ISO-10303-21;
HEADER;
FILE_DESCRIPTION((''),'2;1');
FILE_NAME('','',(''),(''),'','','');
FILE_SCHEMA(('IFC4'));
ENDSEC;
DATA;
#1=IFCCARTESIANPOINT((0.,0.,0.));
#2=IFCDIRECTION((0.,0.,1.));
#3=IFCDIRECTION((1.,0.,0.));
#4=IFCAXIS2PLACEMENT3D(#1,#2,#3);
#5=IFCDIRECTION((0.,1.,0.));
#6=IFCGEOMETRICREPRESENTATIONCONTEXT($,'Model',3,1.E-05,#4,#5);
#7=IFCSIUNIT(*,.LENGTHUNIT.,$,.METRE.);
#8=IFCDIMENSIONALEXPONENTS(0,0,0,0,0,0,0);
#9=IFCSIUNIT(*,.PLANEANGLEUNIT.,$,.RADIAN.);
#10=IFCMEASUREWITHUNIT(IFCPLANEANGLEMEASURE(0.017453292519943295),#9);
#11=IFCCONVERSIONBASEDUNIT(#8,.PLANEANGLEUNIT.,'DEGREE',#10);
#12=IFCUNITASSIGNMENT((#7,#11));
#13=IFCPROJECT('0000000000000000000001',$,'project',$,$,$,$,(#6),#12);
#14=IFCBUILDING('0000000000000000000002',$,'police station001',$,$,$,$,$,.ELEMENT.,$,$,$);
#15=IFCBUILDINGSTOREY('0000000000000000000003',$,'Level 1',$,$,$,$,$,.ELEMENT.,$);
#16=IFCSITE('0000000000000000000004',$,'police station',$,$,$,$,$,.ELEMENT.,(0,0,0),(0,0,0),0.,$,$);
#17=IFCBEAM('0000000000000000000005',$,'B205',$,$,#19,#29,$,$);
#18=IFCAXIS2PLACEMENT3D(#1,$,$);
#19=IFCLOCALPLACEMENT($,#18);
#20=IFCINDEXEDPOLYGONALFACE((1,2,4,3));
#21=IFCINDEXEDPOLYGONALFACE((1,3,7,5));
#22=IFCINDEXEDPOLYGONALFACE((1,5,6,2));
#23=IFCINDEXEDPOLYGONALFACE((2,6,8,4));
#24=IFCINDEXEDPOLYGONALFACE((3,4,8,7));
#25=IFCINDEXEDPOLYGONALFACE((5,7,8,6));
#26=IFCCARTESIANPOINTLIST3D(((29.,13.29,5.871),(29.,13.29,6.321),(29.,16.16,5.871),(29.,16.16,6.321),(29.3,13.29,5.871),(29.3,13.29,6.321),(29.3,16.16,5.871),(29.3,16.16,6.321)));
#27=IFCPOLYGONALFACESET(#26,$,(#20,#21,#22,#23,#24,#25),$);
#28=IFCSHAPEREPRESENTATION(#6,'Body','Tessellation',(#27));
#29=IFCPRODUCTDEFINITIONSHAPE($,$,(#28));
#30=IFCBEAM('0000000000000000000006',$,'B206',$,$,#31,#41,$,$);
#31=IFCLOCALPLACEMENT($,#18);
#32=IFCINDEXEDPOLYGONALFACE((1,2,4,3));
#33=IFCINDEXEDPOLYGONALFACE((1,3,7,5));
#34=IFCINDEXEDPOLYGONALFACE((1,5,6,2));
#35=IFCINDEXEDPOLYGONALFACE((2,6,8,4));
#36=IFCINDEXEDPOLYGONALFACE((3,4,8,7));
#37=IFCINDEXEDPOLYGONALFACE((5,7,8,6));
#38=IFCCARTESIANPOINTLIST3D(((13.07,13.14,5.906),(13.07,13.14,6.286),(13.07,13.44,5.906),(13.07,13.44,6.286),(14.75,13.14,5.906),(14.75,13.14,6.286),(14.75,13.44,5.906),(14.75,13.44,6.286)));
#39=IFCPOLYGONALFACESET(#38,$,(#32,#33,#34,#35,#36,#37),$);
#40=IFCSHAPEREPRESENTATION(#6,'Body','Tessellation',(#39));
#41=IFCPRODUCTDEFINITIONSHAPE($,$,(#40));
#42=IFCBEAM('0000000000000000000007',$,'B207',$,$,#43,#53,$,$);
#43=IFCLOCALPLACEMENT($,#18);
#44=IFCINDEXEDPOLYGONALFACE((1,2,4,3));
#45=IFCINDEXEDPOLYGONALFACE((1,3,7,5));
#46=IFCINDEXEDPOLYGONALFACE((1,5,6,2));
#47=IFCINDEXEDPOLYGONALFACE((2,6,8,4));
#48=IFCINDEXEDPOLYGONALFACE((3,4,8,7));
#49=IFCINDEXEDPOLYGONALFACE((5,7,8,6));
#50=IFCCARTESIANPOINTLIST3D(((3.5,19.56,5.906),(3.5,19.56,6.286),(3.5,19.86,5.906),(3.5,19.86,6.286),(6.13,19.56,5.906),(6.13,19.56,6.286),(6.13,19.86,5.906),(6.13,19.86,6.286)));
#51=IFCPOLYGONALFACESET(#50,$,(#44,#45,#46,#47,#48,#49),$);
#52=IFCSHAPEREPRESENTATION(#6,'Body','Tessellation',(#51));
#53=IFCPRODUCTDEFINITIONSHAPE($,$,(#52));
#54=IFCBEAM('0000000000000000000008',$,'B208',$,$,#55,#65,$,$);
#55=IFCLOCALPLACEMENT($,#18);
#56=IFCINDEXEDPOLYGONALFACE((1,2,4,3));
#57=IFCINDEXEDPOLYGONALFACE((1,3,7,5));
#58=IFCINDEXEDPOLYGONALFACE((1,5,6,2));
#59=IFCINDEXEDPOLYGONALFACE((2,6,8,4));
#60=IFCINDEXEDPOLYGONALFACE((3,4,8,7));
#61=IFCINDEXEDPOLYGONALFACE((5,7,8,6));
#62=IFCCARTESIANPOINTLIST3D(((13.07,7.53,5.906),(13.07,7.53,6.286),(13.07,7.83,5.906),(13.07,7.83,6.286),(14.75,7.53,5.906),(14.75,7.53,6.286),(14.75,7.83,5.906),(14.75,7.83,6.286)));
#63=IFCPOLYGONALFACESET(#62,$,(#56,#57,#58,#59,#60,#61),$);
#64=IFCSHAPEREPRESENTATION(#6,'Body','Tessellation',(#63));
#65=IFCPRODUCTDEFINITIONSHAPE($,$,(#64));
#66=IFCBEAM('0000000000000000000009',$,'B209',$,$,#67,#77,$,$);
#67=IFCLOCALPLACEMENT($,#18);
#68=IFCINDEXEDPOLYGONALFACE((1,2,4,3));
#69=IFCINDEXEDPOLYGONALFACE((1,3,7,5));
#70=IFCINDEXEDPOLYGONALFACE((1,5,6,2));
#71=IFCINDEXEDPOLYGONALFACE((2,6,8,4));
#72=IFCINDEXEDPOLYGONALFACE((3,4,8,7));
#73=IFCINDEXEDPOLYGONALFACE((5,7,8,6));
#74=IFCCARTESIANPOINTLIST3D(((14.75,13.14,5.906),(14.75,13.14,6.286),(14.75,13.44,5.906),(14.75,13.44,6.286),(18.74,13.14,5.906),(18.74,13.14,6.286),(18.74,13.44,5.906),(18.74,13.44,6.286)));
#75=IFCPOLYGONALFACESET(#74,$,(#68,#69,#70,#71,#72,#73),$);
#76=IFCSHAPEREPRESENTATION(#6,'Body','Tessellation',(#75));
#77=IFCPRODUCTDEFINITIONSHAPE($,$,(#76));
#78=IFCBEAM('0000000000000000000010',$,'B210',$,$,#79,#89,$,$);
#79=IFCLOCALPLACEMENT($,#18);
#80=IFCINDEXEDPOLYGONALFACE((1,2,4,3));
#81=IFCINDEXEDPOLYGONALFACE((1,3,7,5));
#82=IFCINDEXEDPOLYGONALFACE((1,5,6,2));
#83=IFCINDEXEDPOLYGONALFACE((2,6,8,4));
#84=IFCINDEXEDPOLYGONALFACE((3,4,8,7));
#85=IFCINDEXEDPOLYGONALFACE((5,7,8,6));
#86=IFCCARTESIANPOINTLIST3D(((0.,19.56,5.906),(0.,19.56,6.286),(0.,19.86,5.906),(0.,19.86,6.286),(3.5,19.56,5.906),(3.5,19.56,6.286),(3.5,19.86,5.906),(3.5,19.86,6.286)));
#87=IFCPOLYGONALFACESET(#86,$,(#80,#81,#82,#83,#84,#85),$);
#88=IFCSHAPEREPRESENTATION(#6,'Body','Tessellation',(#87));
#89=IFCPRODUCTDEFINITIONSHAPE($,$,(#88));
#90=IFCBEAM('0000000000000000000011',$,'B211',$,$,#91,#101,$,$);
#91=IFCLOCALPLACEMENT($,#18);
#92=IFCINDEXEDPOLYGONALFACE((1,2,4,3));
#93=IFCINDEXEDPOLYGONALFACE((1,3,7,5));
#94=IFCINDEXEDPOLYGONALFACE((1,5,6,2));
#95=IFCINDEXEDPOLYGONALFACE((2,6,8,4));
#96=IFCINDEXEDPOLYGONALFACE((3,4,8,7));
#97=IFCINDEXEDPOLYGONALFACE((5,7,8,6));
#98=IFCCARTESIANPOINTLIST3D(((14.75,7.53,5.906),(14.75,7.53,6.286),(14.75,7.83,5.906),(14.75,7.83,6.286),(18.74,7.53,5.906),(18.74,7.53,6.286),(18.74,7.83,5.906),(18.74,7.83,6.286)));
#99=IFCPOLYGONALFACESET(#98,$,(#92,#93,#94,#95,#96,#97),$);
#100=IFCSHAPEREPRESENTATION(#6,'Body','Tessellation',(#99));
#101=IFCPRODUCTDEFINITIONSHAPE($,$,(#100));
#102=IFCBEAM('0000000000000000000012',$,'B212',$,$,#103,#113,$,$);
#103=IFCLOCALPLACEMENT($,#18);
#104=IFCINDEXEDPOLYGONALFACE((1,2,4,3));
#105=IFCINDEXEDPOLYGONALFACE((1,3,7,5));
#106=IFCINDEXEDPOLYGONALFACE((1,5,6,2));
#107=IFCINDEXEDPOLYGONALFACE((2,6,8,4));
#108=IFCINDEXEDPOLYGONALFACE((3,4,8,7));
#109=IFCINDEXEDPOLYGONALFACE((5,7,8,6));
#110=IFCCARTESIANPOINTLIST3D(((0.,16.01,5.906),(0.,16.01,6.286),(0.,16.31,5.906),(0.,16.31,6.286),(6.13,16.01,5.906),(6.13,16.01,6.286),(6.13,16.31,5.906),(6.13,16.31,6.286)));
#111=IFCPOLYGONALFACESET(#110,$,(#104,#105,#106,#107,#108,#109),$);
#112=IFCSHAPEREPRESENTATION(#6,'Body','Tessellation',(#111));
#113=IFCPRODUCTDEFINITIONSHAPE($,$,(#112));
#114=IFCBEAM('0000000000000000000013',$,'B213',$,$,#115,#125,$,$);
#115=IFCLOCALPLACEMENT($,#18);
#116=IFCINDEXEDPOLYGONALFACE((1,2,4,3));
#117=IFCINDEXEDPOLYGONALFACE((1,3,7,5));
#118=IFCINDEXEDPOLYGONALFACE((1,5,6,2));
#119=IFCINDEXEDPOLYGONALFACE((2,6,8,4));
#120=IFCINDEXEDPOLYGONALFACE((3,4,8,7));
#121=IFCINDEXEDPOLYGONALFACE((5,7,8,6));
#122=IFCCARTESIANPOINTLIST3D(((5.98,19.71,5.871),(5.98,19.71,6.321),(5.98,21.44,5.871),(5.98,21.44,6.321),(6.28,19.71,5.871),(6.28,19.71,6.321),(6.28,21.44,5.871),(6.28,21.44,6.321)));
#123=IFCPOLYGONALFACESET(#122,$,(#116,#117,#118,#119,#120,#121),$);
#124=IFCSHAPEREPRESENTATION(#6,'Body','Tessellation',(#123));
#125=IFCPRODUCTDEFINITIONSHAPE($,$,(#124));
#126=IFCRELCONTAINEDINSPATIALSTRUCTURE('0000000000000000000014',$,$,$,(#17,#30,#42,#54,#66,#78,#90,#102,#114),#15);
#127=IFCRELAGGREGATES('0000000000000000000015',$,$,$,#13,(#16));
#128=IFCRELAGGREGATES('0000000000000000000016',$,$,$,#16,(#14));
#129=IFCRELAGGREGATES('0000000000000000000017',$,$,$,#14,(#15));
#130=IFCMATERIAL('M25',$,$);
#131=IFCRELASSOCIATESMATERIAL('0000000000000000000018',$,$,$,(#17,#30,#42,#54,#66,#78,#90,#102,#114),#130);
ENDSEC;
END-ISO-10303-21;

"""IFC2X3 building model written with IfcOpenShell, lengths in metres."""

from ifc_helpers import new_model, entity, si_unit, converted_unit, direction, frame, frame_2d, origin_with_axes, place, context, project, spatial, rectangle, extrude, material, element, save


model = new_model("IFC2X3")

# Units and contexts
model_context = context("Model", 3, precision=1e-05, world=origin_with_axes(), true_north=direction((0.0, 1.0, 0.0)))
ifc_project = project(units=[si_unit("LENGTHUNIT", "METRE"), converted_unit("PLANEANGLEUNIT", "DEGREE", entity("IfcPlaneAngleMeasure", 0.017453292519943295), si_unit("PLANEANGLEUNIT", "RADIAN"), dimensions=[0, 0, 0, 0, 0, 0, 0])], contexts=[model_context])

# Site, building, storey
site = spatial("IfcSite", under=ifc_project, Name="police station", CompositionType="ELEMENT", RefLatitude=(0, 0, 0), RefLongitude=(0, 0, 0), RefElevation=0.0)
building = spatial("IfcBuilding", under=site, Name="police station001", CompositionType="ELEMENT")
storey = spatial("IfcBuildingStorey", under=building, Name="Level 1", CompositionType="ELEMENT")

# Beams
ifc_material = material(Name="M25")
placement = place(None, origin_with_axes())
element("IfcBeam", 1, at=placement, inside=storey, material=ifc_material, Name="B205", context=model_context, shape_type="SweptSolid", body=[
    extrude(rectangle(XDim=0.3, YDim=0.45, at=frame_2d((0.0, 0.0), x_axis=(0.0, 1.0, 0.0))), frame((29.15, 13.29, 6.096), z_axis=(0.0, 1.0, 0.0), x_axis=(0.0, 0.0, -1.0)), (0.0, 0.0, 1.0), 2.87),
])
element("IfcBeam", 2, at=placement, inside=storey, material=ifc_material, Name="B206", context=model_context, shape_type="SweptSolid", body=[
    extrude(rectangle(XDim=0.3, YDim=0.38, at=frame_2d((0.0, 0.0), x_axis=(0.0, 1.0, 0.0))), frame((13.07, 13.29, 6.096), z_axis=(1.0, 0.0, 0.0), x_axis=(0.0, 0.0, -1.0)), (0.0, 0.0, 1.0), 1.68),
])
element("IfcBeam", 3, at=placement, inside=storey, material=ifc_material, Name="B207", context=model_context, shape_type="SweptSolid", body=[
    extrude(rectangle(XDim=0.3, YDim=0.38, at=frame_2d((0.0, 0.0), x_axis=(0.0, 1.0, 0.0))), frame((3.5, 19.71, 6.096), z_axis=(1.0, 0.0, 0.0), x_axis=(0.0, 0.0, -1.0)), (0.0, 0.0, 1.0), 2.63),
])
element("IfcBeam", 4, at=placement, inside=storey, material=ifc_material, Name="B208", context=model_context, shape_type="SweptSolid", body=[
    extrude(rectangle(XDim=0.3, YDim=0.38, at=frame_2d((0.0, 0.0), x_axis=(0.0, 1.0, 0.0))), frame((13.07, 7.68, 6.096), z_axis=(1.0, 0.0, 0.0), x_axis=(0.0, 0.0, -1.0)), (0.0, 0.0, 1.0), 1.68),
])
element("IfcBeam", 5, at=placement, inside=storey, material=ifc_material, Name="B209", context=model_context, shape_type="SweptSolid", body=[
    extrude(rectangle(XDim=0.3, YDim=0.38, at=frame_2d((0.0, 0.0), x_axis=(0.0, 1.0, 0.0))), frame((14.75, 13.29, 6.096), z_axis=(1.0, 0.0, 0.0), x_axis=(0.0, 0.0, -1.0)), (0.0, 0.0, 1.0), 3.99),
])
element("IfcBeam", 6, at=placement, inside=storey, material=ifc_material, Name="B210", context=model_context, shape_type="SweptSolid", body=[
    extrude(rectangle(XDim=0.3, YDim=0.38, at=frame_2d((0.0, 0.0), x_axis=(0.0, 1.0, 0.0))), frame((0.0, 19.71, 6.096), z_axis=(1.0, 0.0, 0.0), x_axis=(0.0, 0.0, -1.0)), (0.0, 0.0, 1.0), 3.5),
])
element("IfcBeam", 7, at=placement, inside=storey, material=ifc_material, Name="B211", context=model_context, shape_type="SweptSolid", body=[
    extrude(rectangle(XDim=0.3, YDim=0.38, at=frame_2d((0.0, 0.0), x_axis=(0.0, 1.0, 0.0))), frame((14.75, 7.68, 6.096), z_axis=(1.0, 0.0, 0.0), x_axis=(0.0, 0.0, -1.0)), (0.0, 0.0, 1.0), 3.99),
])
element("IfcBeam", 8, at=placement, inside=storey, material=ifc_material, Name="B212", context=model_context, shape_type="SweptSolid", body=[
    extrude(rectangle(XDim=0.3, YDim=0.38, at=frame_2d((0.0, 0.0), x_axis=(0.0, 1.0, 0.0))), frame((6.13, 16.16, 6.096), z_axis=(-1.0, 0.0, 0.0), x_axis=(0.0, 0.0, -1.0)), (0.0, 0.0, 1.0), 6.13),
])
element("IfcBeam", 9, at=placement, inside=storey, material=ifc_material, Name="B213", context=model_context, shape_type="SweptSolid", body=[
    extrude(rectangle(XDim=0.3, YDim=0.45, at=frame_2d((0.0, 0.0), x_axis=(0.0, 1.0, 0.0))), frame((6.13, 19.71, 6.096), z_axis=(0.0, 1.0, 0.0), x_axis=(0.0, 0.0, -1.0)), (0.0, 0.0, 1.0), 1.73),
])

save(model, "model.ifc")
